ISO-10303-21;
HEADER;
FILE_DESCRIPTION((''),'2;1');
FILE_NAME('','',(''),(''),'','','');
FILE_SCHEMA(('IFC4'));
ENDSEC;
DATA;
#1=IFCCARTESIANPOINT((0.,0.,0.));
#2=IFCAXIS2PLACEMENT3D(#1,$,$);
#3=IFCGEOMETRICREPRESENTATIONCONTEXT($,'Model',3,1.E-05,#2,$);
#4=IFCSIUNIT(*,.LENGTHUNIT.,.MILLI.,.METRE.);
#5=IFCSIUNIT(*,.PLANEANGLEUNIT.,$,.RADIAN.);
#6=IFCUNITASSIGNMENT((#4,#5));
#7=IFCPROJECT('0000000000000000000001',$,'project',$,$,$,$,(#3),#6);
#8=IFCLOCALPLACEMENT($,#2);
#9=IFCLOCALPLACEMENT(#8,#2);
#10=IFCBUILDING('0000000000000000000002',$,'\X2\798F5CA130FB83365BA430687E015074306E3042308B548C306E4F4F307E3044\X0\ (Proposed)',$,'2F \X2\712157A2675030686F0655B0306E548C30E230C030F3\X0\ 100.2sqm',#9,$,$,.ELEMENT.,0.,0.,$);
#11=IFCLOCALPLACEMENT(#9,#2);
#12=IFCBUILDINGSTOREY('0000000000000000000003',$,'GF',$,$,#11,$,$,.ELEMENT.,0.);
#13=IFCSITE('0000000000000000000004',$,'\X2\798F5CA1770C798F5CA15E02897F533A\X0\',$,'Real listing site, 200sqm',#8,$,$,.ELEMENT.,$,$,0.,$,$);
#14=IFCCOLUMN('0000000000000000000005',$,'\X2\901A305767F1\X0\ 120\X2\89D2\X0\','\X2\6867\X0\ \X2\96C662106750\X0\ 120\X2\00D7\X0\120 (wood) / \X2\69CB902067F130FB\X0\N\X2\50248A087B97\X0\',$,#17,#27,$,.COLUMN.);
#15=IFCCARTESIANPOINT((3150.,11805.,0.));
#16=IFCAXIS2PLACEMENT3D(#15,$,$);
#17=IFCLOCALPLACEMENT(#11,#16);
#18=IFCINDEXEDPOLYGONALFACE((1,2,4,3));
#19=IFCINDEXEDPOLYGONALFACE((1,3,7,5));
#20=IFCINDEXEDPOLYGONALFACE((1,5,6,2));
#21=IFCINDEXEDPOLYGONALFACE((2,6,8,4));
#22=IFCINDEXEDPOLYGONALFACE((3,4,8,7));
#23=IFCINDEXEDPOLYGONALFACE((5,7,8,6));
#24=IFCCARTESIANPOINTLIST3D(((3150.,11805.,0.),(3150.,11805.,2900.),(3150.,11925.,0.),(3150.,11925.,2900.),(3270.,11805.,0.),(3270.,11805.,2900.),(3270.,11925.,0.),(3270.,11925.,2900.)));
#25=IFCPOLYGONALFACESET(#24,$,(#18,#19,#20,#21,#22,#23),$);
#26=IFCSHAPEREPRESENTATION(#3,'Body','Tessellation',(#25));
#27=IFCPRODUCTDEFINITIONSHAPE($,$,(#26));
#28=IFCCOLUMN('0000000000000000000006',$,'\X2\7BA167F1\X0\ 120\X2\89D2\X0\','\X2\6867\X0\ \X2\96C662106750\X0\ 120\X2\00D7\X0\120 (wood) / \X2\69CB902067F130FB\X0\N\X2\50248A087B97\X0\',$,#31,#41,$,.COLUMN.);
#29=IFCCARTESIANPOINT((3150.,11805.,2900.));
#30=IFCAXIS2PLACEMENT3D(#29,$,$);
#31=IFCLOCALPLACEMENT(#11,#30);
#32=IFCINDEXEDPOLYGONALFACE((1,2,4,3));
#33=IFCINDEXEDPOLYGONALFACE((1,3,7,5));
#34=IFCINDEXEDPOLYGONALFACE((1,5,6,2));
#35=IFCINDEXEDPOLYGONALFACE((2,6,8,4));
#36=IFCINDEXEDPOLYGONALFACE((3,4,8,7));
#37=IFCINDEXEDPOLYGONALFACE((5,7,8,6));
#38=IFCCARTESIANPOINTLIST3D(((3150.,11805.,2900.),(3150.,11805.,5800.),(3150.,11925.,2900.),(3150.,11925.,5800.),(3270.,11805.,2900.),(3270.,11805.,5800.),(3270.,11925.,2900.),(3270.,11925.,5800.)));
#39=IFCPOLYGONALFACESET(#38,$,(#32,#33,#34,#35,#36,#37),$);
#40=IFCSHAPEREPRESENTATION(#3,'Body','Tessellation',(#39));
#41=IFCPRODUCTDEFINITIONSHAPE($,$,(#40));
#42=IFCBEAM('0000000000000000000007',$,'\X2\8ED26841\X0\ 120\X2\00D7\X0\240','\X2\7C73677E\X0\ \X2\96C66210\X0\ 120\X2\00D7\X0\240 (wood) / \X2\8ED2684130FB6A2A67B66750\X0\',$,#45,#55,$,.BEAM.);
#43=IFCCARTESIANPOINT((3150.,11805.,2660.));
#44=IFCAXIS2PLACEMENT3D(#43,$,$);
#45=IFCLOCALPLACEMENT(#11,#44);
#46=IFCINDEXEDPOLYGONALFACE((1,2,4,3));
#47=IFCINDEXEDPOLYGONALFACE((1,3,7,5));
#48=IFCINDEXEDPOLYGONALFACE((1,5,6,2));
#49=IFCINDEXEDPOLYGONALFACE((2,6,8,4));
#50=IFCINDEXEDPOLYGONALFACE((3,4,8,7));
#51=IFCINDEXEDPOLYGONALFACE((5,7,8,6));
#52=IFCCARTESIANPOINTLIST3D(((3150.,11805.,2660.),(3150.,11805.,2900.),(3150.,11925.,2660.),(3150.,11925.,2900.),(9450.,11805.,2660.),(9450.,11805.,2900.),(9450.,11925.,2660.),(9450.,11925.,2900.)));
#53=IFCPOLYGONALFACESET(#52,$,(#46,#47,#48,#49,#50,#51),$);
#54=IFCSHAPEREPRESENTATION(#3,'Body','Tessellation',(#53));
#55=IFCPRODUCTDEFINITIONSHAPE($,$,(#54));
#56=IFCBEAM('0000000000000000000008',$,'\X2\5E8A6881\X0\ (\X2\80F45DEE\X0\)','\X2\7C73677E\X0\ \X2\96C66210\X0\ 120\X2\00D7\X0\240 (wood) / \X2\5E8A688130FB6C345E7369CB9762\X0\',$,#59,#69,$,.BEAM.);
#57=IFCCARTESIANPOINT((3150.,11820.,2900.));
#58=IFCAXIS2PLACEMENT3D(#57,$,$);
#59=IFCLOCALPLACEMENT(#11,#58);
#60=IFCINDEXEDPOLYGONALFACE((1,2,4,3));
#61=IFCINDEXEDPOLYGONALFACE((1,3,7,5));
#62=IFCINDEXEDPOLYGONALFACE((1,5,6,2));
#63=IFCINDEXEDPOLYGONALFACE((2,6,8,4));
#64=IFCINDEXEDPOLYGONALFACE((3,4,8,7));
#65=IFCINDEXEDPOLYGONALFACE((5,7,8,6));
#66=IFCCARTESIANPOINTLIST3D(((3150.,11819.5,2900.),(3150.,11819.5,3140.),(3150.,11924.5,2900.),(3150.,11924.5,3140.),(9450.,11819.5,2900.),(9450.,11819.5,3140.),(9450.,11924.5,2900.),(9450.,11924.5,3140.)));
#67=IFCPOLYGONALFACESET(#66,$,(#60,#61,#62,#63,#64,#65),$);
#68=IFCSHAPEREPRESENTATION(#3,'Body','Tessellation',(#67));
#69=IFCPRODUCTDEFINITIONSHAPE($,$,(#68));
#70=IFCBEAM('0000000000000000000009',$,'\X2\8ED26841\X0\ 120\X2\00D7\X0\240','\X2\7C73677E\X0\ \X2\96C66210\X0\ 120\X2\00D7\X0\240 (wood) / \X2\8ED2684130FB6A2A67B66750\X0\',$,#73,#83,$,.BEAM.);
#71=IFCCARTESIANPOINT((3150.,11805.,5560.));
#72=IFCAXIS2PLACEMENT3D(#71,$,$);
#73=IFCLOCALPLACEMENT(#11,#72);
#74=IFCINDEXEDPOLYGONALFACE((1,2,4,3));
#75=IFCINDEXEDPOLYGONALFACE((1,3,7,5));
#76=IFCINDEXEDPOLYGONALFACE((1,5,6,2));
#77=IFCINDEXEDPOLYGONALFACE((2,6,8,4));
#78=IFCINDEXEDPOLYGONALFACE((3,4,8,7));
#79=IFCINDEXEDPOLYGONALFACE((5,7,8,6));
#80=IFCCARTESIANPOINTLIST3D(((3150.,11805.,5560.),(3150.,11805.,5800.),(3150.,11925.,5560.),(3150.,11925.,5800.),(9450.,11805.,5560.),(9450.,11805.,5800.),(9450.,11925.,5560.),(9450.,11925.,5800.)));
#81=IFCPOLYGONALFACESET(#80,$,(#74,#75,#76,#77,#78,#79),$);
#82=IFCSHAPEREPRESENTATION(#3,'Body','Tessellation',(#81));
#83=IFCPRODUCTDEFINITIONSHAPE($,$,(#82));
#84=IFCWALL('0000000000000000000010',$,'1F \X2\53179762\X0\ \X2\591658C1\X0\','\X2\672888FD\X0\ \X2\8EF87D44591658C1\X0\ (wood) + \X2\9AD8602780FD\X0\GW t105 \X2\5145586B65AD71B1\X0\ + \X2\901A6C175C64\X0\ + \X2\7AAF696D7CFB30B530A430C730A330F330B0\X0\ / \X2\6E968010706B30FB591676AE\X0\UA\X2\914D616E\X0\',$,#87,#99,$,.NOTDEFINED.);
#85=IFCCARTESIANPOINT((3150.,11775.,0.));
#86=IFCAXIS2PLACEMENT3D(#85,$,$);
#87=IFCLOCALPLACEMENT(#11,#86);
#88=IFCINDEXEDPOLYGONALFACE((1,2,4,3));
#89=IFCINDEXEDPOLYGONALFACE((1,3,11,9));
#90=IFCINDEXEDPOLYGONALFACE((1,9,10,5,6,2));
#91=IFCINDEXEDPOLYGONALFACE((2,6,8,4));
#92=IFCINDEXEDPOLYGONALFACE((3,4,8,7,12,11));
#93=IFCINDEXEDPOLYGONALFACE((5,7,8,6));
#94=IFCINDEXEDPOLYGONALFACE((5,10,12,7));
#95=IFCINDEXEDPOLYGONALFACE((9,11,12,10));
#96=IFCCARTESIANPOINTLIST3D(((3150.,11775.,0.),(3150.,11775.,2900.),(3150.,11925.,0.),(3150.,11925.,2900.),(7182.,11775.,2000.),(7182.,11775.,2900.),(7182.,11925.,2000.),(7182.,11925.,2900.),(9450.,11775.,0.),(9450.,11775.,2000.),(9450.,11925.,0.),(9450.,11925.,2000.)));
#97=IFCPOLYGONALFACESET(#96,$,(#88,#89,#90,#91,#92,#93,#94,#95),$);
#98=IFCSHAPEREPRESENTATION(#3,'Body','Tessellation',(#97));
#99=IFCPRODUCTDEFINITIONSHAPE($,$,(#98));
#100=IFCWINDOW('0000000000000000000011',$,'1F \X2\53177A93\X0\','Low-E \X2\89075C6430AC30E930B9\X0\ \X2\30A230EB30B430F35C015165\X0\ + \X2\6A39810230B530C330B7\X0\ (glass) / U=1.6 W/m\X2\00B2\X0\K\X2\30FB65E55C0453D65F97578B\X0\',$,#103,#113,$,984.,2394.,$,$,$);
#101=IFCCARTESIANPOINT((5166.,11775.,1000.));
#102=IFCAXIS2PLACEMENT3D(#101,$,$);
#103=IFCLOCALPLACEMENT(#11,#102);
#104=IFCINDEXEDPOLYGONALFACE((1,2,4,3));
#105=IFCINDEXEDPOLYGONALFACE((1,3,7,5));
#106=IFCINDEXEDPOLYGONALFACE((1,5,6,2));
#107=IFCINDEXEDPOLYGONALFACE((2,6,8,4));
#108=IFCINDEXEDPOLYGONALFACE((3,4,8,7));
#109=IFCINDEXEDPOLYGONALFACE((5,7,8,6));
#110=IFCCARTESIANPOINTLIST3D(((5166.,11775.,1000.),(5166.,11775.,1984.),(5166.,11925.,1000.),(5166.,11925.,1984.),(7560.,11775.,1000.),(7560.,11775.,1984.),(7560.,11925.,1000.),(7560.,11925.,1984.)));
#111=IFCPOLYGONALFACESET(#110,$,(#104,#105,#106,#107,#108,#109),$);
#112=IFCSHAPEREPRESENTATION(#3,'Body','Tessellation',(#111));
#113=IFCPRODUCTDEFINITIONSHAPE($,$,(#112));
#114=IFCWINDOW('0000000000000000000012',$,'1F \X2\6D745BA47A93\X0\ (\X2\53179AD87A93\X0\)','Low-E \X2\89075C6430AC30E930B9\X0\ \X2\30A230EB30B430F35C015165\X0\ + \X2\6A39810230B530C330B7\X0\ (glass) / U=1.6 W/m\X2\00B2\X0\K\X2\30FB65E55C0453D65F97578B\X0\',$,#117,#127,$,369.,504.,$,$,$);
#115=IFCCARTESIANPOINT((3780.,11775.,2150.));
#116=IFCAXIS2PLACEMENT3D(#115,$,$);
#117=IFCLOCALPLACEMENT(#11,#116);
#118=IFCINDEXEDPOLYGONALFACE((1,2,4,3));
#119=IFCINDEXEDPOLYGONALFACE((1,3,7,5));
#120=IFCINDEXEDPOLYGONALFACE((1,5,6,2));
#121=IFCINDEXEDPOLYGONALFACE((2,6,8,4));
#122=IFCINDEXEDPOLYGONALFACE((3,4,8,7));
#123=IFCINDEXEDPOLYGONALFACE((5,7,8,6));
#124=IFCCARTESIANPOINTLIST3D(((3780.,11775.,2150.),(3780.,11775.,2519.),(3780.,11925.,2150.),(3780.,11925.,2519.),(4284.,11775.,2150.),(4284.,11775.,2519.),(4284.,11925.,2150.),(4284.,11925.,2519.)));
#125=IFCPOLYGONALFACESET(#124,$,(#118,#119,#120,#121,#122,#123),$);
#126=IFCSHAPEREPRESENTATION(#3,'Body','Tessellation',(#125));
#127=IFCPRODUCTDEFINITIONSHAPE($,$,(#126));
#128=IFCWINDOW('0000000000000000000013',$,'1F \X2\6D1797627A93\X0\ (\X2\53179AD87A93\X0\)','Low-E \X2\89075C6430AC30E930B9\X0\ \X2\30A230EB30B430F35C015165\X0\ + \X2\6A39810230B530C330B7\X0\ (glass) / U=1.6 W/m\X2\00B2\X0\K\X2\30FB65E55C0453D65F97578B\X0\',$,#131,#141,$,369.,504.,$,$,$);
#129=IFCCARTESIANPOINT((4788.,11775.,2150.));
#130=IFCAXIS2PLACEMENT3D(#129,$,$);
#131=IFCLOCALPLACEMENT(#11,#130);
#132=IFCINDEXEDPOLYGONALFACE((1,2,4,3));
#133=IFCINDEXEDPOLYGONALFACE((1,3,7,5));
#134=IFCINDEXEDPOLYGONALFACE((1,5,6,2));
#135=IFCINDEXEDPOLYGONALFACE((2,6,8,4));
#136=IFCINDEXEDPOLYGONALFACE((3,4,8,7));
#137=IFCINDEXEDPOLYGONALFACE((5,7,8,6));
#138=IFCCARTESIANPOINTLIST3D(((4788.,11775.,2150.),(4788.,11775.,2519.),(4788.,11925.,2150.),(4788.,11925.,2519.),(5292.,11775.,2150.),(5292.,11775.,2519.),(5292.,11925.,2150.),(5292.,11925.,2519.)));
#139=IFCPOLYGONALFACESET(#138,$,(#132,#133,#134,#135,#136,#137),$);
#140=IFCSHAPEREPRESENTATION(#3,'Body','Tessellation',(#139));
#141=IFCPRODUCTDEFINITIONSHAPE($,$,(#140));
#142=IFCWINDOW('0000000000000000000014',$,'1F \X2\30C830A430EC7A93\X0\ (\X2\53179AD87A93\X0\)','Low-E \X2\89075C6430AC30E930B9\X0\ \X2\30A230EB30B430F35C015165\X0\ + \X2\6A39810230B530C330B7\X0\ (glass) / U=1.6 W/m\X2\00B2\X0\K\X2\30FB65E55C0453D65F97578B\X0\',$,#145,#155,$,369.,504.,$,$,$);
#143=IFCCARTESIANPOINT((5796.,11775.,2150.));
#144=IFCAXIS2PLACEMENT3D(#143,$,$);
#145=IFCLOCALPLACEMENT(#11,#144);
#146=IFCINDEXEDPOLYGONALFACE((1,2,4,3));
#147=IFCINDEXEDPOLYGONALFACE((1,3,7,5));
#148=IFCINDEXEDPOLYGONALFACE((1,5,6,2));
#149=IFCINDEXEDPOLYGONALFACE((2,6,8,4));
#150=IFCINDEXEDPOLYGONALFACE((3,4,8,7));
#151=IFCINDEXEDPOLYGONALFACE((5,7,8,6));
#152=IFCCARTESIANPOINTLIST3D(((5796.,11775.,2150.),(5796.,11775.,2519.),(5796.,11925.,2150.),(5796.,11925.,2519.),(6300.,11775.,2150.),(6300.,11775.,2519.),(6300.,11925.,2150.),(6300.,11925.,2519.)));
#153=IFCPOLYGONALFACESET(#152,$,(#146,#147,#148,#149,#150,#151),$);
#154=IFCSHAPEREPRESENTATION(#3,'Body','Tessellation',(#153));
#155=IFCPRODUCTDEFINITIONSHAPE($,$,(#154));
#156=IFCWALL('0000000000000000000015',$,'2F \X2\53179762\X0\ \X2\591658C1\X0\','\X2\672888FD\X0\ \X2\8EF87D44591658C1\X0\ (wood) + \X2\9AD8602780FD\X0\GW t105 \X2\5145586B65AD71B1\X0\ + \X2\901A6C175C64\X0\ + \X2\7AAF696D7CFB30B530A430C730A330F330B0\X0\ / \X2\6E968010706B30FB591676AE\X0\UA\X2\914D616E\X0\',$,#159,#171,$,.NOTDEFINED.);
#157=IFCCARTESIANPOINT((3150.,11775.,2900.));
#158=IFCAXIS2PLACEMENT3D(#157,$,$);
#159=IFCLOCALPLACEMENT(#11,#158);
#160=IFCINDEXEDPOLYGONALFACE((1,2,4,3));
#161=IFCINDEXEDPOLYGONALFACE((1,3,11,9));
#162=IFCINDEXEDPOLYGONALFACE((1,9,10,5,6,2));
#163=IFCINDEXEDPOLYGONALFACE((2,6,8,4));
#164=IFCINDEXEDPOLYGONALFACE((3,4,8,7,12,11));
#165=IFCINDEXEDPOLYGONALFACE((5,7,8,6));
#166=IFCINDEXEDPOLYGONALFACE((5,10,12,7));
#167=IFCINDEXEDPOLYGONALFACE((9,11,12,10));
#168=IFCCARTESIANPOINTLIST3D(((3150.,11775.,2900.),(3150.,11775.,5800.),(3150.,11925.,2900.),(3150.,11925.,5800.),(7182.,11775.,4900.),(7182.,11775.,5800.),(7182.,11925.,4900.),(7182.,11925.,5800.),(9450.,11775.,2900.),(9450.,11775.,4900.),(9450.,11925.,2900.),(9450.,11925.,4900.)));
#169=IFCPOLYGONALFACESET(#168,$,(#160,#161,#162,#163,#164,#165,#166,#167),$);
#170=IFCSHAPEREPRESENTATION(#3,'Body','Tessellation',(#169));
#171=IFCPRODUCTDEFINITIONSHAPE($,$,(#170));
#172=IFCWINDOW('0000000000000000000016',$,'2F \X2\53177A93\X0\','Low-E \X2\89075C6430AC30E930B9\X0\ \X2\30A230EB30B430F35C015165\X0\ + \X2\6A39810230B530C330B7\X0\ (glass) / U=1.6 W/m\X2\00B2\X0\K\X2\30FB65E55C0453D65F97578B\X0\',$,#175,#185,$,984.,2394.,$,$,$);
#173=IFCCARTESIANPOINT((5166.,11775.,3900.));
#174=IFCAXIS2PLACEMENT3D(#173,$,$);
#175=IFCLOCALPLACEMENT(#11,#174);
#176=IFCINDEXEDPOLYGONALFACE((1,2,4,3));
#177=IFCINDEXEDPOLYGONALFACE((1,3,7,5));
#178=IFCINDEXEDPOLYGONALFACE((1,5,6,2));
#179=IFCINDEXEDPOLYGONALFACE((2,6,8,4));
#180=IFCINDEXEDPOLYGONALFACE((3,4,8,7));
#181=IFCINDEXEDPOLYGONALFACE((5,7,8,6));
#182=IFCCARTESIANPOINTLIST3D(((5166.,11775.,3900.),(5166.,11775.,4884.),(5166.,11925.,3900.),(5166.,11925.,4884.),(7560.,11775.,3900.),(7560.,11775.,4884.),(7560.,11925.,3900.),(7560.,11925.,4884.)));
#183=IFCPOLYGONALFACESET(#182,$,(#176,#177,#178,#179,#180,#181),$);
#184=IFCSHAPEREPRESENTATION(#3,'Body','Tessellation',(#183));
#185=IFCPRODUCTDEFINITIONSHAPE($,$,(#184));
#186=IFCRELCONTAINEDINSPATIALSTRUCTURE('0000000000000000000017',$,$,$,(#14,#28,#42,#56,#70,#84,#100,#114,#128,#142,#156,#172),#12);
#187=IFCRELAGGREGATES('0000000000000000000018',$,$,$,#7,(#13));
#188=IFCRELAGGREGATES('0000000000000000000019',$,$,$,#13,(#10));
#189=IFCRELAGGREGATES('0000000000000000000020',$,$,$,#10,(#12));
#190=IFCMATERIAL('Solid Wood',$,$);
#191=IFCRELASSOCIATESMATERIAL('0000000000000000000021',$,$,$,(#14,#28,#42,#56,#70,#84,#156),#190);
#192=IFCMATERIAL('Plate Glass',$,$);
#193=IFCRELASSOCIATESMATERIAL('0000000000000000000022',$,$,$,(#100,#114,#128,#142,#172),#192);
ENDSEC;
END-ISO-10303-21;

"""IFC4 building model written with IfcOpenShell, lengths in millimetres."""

from ifc_helpers import new_model, si_unit, frame, frame_2d, origin, place, context, project, spatial, rectangle, extrude, material, element, fill, save


model = new_model("IFC4")

# Units and contexts
model_context = context("Model", 3, precision=1e-05, world=origin())
ifc_project = project(units=[si_unit("LENGTHUNIT", "METRE", prefix="MILLI"), si_unit("PLANEANGLEUNIT", "RADIAN")], contexts=[model_context])

# Site, building, storey
site_placement = place(None, origin())
site = spatial("IfcSite", under=ifc_project, at=site_placement, Name="福岡県福岡市西区", ObjectType="Real listing site, 200sqm", CompositionType="ELEMENT", RefElevation=0.0)
building_placement = place(site_placement, origin())
building = spatial("IfcBuilding", under=site, at=building_placement, Name="福岡・茶室と縁側のある和の住まい (Proposed)", ObjectType="2F 無垢材と漆喰の和モダン 100.2sqm", CompositionType="ELEMENT", ElevationOfRefHeight=0.0, ElevationOfTerrain=0.0)
storey_placement = place(building_placement, origin())
storey = spatial("IfcBuildingStorey", under=building, at=storey_placement, Name="GF", CompositionType="ELEMENT", Elevation=0.0)

# Columns
ifc_material_1 = material(Name="Solid Wood")
column_1_placement = place(storey_placement, frame((3150.0, 11805.0, 0.0)))
element("IfcColumn", 1, at=column_1_placement, inside=storey, material=ifc_material_1, Name="通し柱 120角", Description="桧 集成材 120×120 (wood) / 構造柱・N値計算", PredefinedType="COLUMN", context=model_context, shape_type="SweptSolid", body=[
    extrude(rectangle(XDim=120.0, YDim=120.0, at=frame_2d((60.0, 60.0))), frame((3150.0, 11805.0, 0.0)), (0.0, 0.0, 1.0), 2900.0),
])
column_2_placement = place(storey_placement, frame((3150.0, 11805.0, 2900.0)))
element("IfcColumn", 2, at=column_2_placement, inside=storey, material=ifc_material_1, Name="管柱 120角", Description="桧 集成材 120×120 (wood) / 構造柱・N値計算", PredefinedType="COLUMN", context=model_context, shape_type="SweptSolid", body=[
    extrude(rectangle(XDim=120.0, YDim=120.0, at=frame_2d((60.0, 60.0))), frame((3150.0, 11805.0, 2900.0)), (0.0, 0.0, 1.0), 2900.0),
])

# Beams
beam_1_placement = place(storey_placement, frame((3150.0, 11805.0, 2660.0)))
element("IfcBeam", 3, at=beam_1_placement, inside=storey, material=ifc_material_1, Name="軒桁 120×240", Description="米松 集成 120×240 (wood) / 軒桁・横架材", PredefinedType="BEAM", context=model_context, shape_type="SweptSolid", body=[
    extrude(rectangle(XDim=6300.0, YDim=120.0, at=frame_2d((3150.0, 60.0))), frame((3150.0, 11805.0, 2660.0)), (0.0, 0.0, 1.0), 240.0),
])
beam_2_placement = place(storey_placement, frame((3150.0, 11820.0, 2900.0)))
element("IfcBeam", 4, at=beam_2_placement, inside=storey, material=ifc_material_1, Name="床梁 (胴差)", Description="米松 集成 120×240 (wood) / 床梁・水平構面", PredefinedType="BEAM", context=model_context, shape_type="SweptSolid", body=[
    extrude(rectangle(XDim=6300.0, YDim=105.0, at=frame_2d((3150.0, 52.0))), frame((3150.0, 11820.0, 2900.0)), (0.0, 0.0, 1.0), 240.0),
])
beam_3_placement = place(storey_placement, frame((3150.0, 11805.0, 5560.0)))
element("IfcBeam", 5, at=beam_3_placement, inside=storey, material=ifc_material_1, Name="軒桁 120×240", Description="米松 集成 120×240 (wood) / 軒桁・横架材", PredefinedType="BEAM", context=model_context, shape_type="SweptSolid", body=[
    extrude(rectangle(XDim=6300.0, YDim=120.0, at=frame_2d((3150.0, 60.0))), frame((3150.0, 11805.0, 5560.0)), (0.0, 0.0, 1.0), 240.0),
])

# Wall, openings, windows
wall_1_placement = place(storey_placement, frame((3150.0, 11775.0, 0.0)))
wall_1 = element("IfcWall", 6, at=wall_1_placement, inside=storey, material=ifc_material_1, Name="1F 北面 外壁", Description="木製 軸組外壁 (wood) + 高性能GW t105 充填断熱 + 通気層 + 窯業系サイディング / 準耐火・外皮UA配慮", PredefinedType="NOTDEFINED", context=model_context, shape_type="SweptSolid", body=[
    extrude(rectangle(XDim=6300.0, YDim=150.0, at=frame_2d((3150.0, 75.0))), frame((3150.0, 11775.0, 0.0)), (0.0, 0.0, 1.0), 2900.0),
])
opening_1_placement = place(storey_placement, frame((5166.0, 11775.0, 1000.0)))
opening_1 = element("IfcOpeningElement", 7, at=opening_1_placement, cuts=wall_1, PredefinedType="NOTDEFINED", context=model_context, shape_type="SweptSolid", body=[
    extrude(rectangle(XDim=2394.0, YDim=150.0, at=frame_2d((1197.0, 75.0))), frame((5166.0, 11775.0, 1000.0)), (0.0, 0.0, 1.0), 984.0),
])
opening_2_placement = place(storey_placement, frame((3780.0, 11775.0, 2150.0)))
opening_2 = element("IfcOpeningElement", 8, at=opening_2_placement, cuts=wall_1, PredefinedType="NOTDEFINED", context=model_context, shape_type="SweptSolid", body=[
    extrude(rectangle(XDim=504.0, YDim=150.0, at=frame_2d((252.0, 75.0))), frame((3780.0, 11775.0, 2150.0)), (0.0, 0.0, 1.0), 369.0),
])
opening_3_placement = place(storey_placement, frame((4788.0, 11775.0, 2150.0)))
opening_3 = element("IfcOpeningElement", 9, at=opening_3_placement, cuts=wall_1, PredefinedType="NOTDEFINED", context=model_context, shape_type="SweptSolid", body=[
    extrude(rectangle(XDim=504.0, YDim=150.0, at=frame_2d((252.0, 75.0))), frame((4788.0, 11775.0, 2150.0)), (0.0, 0.0, 1.0), 369.0),
])
opening_4_placement = place(storey_placement, frame((5796.0, 11775.0, 2150.0)))
opening_4 = element("IfcOpeningElement", 10, at=opening_4_placement, cuts=wall_1, PredefinedType="NOTDEFINED", context=model_context, shape_type="SweptSolid", body=[
    extrude(rectangle(XDim=504.0, YDim=150.0, at=frame_2d((252.0, 75.0))), frame((5796.0, 11775.0, 2150.0)), (0.0, 0.0, 1.0), 369.0),
])
ifc_material_2 = material(Name="Plate Glass")
window_1_placement = place(storey_placement, frame((5166.0, 11775.0, 1000.0)))
window_1 = element("IfcWindow", 11, at=window_1_placement, inside=storey, material=ifc_material_2, Name="1F 北窓", Description="Low-E 複層ガラス アルゴン封入 + 樹脂サッシ (glass) / U=1.6 W/m²K・日射取得型", OverallHeight=984.0, OverallWidth=2394.0, context=model_context, shape_type="SweptSolid", body=[
    extrude(rectangle(XDim=2394.0, YDim=150.0, at=frame_2d((1197.0, 75.0))), frame((5166.0, 11775.0, 1000.0)), (0.0, 0.0, 1.0), 984.0),
])
fill(opening_1, window_1)
window_2_placement = place(storey_placement, frame((3780.0, 11775.0, 2150.0)))
window_2 = element("IfcWindow", 12, at=window_2_placement, inside=storey, material=ifc_material_2, Name="1F 浴室窓 (北高窓)", Description="Low-E 複層ガラス アルゴン封入 + 樹脂サッシ (glass) / U=1.6 W/m²K・日射取得型", OverallHeight=369.0, OverallWidth=504.0, context=model_context, shape_type="SweptSolid", body=[
    extrude(rectangle(XDim=504.0, YDim=150.0, at=frame_2d((252.0, 75.0))), frame((3780.0, 11775.0, 2150.0)), (0.0, 0.0, 1.0), 369.0),
])
fill(opening_2, window_2)
window_3_placement = place(storey_placement, frame((4788.0, 11775.0, 2150.0)))
window_3 = element("IfcWindow", 13, at=window_3_placement, inside=storey, material=ifc_material_2, Name="1F 洗面窓 (北高窓)", Description="Low-E 複層ガラス アルゴン封入 + 樹脂サッシ (glass) / U=1.6 W/m²K・日射取得型", OverallHeight=369.0, OverallWidth=504.0, context=model_context, shape_type="SweptSolid", body=[
    extrude(rectangle(XDim=504.0, YDim=150.0, at=frame_2d((252.0, 75.0))), frame((4788.0, 11775.0, 2150.0)), (0.0, 0.0, 1.0), 369.0),
])
fill(opening_3, window_3)
window_4_placement = place(storey_placement, frame((5796.0, 11775.0, 2150.0)))
window_4 = element("IfcWindow", 14, at=window_4_placement, inside=storey, material=ifc_material_2, Name="1F トイレ窓 (北高窓)", Description="Low-E 複層ガラス アルゴン封入 + 樹脂サッシ (glass) / U=1.6 W/m²K・日射取得型", OverallHeight=369.0, OverallWidth=504.0, context=model_context, shape_type="SweptSolid", body=[
    extrude(rectangle(XDim=504.0, YDim=150.0, at=frame_2d((252.0, 75.0))), frame((5796.0, 11775.0, 2150.0)), (0.0, 0.0, 1.0), 369.0),
])
fill(opening_4, window_4)

# Wall, opening, window
wall_2_placement = place(storey_placement, frame((3150.0, 11775.0, 2900.0)))
wall_2 = element("IfcWall", 15, at=wall_2_placement, inside=storey, material=ifc_material_1, Name="2F 北面 外壁", Description="木製 軸組外壁 (wood) + 高性能GW t105 充填断熱 + 通気層 + 窯業系サイディング / 準耐火・外皮UA配慮", PredefinedType="NOTDEFINED", context=model_context, shape_type="SweptSolid", body=[
    extrude(rectangle(XDim=6300.0, YDim=150.0, at=frame_2d((3150.0, 75.0))), frame((3150.0, 11775.0, 2900.0)), (0.0, 0.0, 1.0), 2900.0),
])
opening_5_placement = place(storey_placement, frame((5166.0, 11775.0, 3900.0)))
opening_5 = element("IfcOpeningElement", 16, at=opening_5_placement, cuts=wall_2, PredefinedType="NOTDEFINED", context=model_context, shape_type="SweptSolid", body=[
    extrude(rectangle(XDim=2394.0, YDim=150.0, at=frame_2d((1197.0, 75.0))), frame((5166.0, 11775.0, 3900.0)), (0.0, 0.0, 1.0), 984.0),
])
window_5_placement = place(storey_placement, frame((5166.0, 11775.0, 3900.0)))
window_5 = element("IfcWindow", 17, at=window_5_placement, inside=storey, material=ifc_material_2, Name="2F 北窓", Description="Low-E 複層ガラス アルゴン封入 + 樹脂サッシ (glass) / U=1.6 W/m²K・日射取得型", OverallHeight=984.0, OverallWidth=2394.0, context=model_context, shape_type="SweptSolid", body=[
    extrude(rectangle(XDim=2394.0, YDim=150.0, at=frame_2d((1197.0, 75.0))), frame((5166.0, 11775.0, 3900.0)), (0.0, 0.0, 1.0), 984.0),
])
fill(opening_5, window_5)

save(model, "model.ifc")
